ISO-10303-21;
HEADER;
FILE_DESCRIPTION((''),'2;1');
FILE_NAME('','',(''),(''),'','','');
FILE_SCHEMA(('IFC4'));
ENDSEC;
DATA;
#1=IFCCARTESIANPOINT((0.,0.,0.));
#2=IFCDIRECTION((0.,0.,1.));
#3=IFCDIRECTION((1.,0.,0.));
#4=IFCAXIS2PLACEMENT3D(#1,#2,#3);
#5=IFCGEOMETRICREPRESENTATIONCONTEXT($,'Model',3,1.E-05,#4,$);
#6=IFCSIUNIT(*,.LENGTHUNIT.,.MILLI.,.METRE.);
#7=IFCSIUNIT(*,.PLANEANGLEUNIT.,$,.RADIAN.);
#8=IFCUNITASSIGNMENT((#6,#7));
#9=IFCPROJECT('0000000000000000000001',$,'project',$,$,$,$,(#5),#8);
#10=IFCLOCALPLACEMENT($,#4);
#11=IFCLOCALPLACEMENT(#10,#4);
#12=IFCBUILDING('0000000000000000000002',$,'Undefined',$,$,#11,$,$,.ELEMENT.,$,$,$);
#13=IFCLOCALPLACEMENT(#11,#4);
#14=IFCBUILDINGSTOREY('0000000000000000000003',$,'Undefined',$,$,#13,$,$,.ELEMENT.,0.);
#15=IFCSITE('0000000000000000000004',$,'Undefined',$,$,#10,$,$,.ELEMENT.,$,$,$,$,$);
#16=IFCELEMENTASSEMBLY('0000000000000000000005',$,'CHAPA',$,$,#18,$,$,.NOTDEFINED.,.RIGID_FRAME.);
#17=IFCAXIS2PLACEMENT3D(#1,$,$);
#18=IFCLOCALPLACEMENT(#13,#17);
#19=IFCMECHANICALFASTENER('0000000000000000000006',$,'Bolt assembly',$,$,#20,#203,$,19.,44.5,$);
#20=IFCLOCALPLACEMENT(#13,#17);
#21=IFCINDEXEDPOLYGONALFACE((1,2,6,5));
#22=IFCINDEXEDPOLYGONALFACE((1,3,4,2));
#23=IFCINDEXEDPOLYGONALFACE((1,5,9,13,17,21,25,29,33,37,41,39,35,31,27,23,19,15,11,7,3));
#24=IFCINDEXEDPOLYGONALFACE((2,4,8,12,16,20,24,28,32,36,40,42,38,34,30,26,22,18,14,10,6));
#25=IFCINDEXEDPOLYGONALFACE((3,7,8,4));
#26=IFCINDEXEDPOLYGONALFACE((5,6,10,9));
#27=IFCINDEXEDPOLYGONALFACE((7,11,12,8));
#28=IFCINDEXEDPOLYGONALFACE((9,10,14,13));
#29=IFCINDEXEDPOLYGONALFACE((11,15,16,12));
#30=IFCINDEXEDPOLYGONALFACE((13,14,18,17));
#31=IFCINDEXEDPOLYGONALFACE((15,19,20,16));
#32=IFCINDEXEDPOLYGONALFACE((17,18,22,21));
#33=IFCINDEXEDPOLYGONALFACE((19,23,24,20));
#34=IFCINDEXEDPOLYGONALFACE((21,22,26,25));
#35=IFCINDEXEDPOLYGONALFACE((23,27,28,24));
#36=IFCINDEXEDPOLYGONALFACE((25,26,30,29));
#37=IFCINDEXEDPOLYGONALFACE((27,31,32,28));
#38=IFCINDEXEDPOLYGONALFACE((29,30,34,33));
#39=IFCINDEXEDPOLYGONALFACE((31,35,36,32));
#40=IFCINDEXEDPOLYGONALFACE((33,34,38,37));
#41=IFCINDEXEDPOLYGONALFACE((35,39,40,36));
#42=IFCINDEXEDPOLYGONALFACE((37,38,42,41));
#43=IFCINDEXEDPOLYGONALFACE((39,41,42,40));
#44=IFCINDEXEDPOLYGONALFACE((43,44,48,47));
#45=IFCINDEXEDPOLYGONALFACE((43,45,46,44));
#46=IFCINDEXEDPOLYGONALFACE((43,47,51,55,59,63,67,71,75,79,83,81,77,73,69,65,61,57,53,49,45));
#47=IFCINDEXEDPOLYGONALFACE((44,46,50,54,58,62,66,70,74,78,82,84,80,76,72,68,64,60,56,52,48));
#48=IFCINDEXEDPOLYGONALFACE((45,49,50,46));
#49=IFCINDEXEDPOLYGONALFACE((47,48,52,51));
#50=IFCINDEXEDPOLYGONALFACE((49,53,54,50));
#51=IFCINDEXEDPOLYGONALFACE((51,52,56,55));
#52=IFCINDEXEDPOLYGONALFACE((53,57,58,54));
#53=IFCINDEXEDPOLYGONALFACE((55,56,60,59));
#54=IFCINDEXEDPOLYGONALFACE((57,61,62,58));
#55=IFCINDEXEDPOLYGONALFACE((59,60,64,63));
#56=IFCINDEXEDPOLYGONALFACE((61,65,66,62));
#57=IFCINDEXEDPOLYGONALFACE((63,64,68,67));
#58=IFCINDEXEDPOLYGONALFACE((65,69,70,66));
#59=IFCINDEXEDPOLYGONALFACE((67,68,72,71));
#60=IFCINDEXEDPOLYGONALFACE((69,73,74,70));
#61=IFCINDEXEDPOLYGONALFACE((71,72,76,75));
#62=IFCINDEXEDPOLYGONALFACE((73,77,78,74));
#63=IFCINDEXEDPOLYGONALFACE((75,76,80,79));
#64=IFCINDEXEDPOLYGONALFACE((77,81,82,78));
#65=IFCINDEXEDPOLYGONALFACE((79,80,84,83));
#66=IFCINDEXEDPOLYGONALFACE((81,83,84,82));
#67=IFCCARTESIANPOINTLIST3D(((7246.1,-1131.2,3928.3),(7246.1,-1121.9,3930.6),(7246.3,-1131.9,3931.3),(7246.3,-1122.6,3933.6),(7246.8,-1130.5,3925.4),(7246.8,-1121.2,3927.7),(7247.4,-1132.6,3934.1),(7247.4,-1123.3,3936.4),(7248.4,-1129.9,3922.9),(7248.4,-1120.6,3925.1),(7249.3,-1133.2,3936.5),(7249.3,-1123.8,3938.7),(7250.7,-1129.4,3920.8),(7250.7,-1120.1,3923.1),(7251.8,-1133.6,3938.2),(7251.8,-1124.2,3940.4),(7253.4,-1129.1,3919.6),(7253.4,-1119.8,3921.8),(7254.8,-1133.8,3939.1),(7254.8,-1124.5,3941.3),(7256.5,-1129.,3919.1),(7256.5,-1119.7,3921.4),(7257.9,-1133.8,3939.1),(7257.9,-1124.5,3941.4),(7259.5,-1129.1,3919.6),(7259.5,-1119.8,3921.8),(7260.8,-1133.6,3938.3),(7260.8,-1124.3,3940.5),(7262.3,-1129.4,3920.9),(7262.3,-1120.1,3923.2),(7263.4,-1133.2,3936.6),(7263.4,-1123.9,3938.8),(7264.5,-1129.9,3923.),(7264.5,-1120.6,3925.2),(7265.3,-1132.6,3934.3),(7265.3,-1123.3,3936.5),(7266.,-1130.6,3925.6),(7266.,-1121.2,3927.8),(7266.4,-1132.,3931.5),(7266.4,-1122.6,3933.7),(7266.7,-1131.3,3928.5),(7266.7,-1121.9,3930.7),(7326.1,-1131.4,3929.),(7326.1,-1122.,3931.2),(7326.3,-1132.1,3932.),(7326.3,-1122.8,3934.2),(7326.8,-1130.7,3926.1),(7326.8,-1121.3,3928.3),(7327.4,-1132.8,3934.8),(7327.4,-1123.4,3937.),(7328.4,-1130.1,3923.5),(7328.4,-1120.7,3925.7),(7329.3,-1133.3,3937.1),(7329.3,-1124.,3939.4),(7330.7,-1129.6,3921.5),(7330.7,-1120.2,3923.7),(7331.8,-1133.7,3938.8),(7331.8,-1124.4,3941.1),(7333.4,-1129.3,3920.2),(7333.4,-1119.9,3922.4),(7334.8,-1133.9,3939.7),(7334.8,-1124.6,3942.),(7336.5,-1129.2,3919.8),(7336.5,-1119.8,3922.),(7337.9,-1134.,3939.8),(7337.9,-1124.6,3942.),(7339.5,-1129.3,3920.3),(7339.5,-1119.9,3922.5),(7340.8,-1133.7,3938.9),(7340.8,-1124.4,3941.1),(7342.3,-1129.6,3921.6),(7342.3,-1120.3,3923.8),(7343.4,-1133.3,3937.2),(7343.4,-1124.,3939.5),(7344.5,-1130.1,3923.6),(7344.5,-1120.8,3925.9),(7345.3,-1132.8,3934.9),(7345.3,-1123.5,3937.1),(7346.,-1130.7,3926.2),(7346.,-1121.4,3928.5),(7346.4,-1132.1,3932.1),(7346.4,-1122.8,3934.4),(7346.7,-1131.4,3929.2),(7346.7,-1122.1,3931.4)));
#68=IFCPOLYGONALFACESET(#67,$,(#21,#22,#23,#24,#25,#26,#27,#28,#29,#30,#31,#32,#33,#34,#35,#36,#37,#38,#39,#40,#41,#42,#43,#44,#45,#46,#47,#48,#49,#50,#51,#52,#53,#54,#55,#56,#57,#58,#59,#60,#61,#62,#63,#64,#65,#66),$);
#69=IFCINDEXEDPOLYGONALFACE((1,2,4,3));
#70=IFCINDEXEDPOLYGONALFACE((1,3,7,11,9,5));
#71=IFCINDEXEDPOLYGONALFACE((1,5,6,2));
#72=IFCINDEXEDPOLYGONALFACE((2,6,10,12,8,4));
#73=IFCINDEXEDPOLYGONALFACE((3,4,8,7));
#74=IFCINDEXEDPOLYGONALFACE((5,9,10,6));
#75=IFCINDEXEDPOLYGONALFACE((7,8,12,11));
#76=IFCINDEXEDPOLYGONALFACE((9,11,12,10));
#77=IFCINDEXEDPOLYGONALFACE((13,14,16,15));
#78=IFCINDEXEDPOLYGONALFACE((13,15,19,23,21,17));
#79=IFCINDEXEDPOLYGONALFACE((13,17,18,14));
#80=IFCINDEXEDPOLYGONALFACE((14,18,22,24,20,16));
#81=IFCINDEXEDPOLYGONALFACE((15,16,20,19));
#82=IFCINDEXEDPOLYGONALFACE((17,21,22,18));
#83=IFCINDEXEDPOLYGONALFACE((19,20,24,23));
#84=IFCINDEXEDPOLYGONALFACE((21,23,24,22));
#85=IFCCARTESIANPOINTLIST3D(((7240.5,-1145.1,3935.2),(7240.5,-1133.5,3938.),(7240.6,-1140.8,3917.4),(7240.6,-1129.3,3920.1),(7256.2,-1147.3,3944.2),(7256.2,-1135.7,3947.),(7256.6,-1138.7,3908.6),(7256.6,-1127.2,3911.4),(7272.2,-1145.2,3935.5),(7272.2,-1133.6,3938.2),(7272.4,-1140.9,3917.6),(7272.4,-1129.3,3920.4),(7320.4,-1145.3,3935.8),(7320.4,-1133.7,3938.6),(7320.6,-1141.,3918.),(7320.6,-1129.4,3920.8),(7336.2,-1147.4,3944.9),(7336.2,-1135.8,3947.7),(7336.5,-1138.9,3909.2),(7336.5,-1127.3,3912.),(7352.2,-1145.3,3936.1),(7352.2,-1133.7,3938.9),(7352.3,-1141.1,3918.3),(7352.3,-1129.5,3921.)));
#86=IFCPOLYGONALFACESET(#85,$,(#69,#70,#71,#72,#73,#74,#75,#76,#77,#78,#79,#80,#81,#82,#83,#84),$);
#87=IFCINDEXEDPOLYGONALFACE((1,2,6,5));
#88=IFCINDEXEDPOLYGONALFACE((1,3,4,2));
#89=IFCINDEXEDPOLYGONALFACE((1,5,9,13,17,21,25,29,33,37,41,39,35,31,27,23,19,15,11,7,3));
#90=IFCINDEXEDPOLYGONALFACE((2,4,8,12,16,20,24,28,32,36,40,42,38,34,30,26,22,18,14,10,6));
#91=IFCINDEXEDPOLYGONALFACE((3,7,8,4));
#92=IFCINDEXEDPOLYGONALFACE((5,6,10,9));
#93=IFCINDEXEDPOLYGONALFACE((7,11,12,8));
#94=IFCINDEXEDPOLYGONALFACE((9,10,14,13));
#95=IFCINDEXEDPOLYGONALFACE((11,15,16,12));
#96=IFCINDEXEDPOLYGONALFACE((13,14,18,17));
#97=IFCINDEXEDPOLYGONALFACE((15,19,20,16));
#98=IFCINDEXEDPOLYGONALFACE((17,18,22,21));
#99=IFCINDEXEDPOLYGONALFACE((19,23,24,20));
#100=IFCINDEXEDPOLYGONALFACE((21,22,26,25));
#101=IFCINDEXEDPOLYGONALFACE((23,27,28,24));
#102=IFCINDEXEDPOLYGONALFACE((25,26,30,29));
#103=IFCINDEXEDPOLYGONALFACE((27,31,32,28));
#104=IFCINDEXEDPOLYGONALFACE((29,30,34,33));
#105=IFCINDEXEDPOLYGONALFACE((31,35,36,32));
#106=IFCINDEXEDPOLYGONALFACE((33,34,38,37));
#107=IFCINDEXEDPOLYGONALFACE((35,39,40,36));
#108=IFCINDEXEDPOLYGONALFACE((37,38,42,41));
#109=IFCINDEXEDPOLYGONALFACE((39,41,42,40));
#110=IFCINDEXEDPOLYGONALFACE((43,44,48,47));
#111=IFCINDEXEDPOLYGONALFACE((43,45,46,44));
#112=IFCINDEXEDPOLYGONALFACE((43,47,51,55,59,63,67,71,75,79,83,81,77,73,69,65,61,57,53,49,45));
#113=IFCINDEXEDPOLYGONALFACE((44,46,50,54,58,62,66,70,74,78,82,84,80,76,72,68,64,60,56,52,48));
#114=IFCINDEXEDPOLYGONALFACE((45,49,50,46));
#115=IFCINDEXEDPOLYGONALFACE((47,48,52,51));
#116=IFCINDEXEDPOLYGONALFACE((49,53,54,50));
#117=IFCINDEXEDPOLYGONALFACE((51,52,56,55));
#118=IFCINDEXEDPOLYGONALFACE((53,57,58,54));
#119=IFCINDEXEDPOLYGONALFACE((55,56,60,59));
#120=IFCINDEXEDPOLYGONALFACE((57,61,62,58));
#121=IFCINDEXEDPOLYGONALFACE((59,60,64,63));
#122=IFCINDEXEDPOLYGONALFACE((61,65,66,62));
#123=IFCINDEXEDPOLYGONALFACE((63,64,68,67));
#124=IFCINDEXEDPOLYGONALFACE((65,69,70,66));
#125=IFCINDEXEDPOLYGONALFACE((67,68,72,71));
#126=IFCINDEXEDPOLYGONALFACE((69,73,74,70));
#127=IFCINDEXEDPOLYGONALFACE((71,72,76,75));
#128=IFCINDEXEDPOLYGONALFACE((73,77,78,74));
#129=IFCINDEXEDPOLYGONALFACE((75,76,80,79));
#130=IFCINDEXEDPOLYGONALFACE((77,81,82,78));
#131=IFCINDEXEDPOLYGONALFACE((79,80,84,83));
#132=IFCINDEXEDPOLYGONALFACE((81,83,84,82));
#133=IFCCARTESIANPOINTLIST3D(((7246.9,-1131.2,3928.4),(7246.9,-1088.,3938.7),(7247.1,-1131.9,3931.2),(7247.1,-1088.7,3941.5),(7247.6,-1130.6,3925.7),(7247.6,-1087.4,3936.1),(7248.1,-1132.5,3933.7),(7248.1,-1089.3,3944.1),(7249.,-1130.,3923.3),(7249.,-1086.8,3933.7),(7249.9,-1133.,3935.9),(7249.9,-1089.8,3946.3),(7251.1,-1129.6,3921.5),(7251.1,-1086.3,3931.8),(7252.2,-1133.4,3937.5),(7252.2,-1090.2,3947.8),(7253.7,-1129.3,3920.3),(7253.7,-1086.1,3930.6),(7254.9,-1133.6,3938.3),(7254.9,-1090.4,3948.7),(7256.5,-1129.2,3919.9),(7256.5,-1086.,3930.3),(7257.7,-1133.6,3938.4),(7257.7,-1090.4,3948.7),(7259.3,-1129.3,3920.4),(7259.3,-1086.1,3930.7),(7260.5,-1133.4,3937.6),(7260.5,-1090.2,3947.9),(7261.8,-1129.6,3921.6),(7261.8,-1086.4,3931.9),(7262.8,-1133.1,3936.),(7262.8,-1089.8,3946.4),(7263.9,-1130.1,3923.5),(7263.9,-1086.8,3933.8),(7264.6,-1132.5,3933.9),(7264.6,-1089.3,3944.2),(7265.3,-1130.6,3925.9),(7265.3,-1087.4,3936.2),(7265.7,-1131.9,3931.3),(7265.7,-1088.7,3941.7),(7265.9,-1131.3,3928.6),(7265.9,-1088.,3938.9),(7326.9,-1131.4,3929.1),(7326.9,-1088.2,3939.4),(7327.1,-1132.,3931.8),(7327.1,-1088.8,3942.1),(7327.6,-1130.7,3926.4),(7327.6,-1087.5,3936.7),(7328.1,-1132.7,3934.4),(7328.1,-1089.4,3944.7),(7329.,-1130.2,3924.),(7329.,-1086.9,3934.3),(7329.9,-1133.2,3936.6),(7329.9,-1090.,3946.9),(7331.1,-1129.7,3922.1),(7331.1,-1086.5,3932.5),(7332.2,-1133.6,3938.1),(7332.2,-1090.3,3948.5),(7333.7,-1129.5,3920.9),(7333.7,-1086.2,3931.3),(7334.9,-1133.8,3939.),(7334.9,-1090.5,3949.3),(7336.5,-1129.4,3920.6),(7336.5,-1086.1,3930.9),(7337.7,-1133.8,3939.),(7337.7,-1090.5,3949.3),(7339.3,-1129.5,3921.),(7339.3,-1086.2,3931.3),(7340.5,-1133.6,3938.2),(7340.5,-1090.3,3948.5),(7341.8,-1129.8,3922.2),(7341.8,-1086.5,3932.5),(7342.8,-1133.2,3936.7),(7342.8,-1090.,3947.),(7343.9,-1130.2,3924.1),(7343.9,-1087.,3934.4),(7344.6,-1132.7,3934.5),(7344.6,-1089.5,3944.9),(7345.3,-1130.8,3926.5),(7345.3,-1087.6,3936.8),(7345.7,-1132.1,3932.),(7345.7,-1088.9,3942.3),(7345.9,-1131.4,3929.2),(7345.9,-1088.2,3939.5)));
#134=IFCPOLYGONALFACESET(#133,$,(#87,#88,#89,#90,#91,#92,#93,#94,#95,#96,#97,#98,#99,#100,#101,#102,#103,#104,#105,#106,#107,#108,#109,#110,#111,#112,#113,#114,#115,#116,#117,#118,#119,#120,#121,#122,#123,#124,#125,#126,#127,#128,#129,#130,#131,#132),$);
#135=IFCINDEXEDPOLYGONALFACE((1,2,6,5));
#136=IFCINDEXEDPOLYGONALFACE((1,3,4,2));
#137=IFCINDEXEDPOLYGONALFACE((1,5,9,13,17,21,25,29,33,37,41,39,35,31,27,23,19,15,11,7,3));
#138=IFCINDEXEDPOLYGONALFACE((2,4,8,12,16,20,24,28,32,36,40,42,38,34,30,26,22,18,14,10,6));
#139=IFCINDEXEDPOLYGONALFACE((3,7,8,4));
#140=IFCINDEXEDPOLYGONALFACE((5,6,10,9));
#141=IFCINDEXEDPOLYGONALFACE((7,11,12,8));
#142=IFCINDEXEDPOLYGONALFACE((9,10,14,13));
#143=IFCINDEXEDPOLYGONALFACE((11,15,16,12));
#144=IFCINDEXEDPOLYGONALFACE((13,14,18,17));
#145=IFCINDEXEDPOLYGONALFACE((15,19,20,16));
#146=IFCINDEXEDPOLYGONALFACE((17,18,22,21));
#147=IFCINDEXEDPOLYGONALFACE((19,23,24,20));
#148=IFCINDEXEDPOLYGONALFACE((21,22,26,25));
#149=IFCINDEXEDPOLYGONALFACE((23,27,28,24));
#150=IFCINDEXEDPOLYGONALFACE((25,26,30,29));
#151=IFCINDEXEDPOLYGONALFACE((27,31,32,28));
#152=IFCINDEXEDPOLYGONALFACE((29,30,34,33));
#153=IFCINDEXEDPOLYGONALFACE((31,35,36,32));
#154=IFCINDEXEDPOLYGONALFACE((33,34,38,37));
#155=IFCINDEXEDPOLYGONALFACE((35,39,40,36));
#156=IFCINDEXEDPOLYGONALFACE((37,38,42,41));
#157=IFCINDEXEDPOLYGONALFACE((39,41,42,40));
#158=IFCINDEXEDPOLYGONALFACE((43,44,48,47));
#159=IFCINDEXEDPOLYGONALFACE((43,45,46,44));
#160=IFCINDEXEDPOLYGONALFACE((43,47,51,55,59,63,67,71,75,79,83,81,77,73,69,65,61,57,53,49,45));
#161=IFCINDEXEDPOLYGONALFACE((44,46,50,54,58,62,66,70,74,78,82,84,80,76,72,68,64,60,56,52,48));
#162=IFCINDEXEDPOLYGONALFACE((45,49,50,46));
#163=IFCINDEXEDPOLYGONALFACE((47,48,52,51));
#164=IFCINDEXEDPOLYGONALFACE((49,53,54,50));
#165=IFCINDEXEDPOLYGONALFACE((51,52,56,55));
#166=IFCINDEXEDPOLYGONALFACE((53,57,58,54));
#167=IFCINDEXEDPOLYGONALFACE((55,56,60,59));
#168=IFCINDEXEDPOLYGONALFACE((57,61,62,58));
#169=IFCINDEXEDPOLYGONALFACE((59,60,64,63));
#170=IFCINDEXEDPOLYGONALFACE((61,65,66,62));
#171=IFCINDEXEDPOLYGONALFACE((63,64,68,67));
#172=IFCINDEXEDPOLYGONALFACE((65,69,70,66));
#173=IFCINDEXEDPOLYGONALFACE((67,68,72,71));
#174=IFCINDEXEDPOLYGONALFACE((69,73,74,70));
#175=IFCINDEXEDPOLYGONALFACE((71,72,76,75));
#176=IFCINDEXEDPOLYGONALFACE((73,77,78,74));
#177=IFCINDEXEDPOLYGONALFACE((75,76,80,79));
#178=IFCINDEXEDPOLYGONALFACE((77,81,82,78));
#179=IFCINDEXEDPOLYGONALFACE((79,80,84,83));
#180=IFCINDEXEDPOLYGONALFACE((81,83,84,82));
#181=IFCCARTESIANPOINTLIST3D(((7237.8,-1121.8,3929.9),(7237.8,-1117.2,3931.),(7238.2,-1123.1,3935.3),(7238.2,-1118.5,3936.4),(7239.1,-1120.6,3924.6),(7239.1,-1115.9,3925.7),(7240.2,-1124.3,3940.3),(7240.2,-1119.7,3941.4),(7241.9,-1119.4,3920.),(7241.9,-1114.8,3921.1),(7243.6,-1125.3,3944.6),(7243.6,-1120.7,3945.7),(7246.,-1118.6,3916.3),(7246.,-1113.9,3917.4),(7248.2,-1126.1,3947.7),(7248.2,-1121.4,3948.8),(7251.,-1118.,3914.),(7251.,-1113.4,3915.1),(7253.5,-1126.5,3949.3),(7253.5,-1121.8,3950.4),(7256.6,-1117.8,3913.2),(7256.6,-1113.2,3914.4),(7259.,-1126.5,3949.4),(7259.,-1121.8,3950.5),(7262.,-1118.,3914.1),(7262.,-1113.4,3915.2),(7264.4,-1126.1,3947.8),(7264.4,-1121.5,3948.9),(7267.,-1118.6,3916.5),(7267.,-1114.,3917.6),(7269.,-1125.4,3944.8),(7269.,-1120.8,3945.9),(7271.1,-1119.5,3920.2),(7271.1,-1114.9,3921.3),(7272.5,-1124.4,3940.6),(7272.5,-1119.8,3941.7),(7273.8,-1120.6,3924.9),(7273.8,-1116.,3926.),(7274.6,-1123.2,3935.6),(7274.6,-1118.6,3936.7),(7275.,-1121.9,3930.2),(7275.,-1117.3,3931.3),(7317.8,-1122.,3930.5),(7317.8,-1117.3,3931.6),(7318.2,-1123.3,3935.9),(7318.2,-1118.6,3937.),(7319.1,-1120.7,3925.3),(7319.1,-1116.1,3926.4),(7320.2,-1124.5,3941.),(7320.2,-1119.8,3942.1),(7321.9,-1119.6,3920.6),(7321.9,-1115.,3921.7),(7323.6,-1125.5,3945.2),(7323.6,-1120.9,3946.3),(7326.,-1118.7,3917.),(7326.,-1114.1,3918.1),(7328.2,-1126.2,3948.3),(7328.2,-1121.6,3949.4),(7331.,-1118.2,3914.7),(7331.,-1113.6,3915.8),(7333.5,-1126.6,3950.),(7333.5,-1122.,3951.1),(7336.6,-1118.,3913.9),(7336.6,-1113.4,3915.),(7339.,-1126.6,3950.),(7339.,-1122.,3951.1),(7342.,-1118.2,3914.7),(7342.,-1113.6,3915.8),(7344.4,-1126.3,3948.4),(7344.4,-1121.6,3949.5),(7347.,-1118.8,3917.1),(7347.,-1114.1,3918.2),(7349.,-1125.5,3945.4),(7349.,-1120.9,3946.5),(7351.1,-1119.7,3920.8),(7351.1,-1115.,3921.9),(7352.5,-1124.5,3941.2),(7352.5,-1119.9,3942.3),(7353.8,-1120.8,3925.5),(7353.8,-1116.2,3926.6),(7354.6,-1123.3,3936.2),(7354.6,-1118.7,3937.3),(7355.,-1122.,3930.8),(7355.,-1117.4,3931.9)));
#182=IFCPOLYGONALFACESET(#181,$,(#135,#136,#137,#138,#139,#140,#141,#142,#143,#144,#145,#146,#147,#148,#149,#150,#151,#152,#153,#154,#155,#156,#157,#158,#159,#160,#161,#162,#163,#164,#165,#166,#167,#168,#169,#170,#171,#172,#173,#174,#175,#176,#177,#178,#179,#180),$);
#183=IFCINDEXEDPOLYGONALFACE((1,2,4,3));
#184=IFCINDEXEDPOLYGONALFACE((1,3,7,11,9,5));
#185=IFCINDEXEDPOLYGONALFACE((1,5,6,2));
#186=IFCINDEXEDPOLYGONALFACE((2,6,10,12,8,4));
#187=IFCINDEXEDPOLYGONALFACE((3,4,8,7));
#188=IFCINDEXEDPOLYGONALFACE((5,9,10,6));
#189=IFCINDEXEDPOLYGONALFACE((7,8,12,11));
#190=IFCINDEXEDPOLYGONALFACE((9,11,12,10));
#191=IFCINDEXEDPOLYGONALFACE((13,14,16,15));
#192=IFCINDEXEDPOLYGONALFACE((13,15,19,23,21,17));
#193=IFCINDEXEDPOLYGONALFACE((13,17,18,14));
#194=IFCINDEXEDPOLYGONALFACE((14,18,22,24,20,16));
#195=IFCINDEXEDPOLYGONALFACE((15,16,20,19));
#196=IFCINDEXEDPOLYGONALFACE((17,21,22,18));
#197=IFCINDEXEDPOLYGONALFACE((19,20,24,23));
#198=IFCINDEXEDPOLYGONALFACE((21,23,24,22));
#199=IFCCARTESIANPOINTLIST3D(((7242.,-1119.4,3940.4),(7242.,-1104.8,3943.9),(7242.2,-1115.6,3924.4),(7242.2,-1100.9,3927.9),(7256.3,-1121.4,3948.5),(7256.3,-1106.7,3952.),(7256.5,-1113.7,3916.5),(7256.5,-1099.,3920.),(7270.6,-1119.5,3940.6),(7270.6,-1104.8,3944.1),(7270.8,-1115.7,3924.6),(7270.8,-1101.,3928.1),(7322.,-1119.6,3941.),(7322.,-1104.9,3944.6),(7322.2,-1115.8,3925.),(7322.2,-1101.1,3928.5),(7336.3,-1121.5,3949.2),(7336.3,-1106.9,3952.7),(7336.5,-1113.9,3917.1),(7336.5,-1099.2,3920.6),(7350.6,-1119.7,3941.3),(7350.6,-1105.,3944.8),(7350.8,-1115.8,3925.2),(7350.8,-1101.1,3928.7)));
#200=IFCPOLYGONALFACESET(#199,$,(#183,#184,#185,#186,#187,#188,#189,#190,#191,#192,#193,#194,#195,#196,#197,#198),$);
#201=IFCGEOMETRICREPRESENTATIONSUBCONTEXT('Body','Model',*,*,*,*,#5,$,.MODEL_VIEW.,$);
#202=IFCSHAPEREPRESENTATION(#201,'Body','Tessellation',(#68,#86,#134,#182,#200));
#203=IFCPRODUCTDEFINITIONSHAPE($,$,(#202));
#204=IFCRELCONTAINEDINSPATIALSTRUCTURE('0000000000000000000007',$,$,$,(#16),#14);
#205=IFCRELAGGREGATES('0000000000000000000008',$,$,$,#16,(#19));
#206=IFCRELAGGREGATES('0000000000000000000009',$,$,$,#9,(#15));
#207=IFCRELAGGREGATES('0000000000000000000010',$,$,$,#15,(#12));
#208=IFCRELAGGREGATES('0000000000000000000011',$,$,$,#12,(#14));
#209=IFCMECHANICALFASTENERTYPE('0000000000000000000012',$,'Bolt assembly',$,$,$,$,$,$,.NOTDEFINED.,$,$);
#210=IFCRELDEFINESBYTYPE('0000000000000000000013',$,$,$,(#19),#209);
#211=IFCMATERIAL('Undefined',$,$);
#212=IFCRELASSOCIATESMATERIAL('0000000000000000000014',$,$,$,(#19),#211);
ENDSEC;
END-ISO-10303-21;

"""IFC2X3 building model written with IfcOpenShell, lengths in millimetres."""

from ifc_helpers import new_model, si_unit, frame, origin_with_axes, origin_2d_with_axis, place, context, subcontext, project, spatial, polyline, circle, outline, extrude, source, transform, mapped, material, type_object, element, aggregate, save


model = new_model("IFC2X3")

# Units and contexts
model_context = context("Model", 3, precision=1e-05, world=origin_with_axes())
body_context = subcontext(model_context, "Body", "Model", "MODEL_VIEW")
ifc_project = project(units=[si_unit("LENGTHUNIT", "METRE", prefix="MILLI"), si_unit("PLANEANGLEUNIT", "RADIAN")], contexts=[model_context])

# Site, building, storey
site_placement = place(None, origin_with_axes())
site = spatial("IfcSite", under=ifc_project, at=site_placement, Name="Undefined", CompositionType="ELEMENT")
building_placement = place(site_placement, origin_with_axes())
building = spatial("IfcBuilding", under=site, at=building_placement, Name="Undefined", CompositionType="ELEMENT")
storey_placement = place(building_placement, origin_with_axes())
storey = spatial("IfcBuildingStorey", under=building, at=storey_placement, Name="Undefined", CompositionType="ELEMENT", Elevation=0.0)

# Element assembly
assembly_1_placement = place(storey_placement, origin_with_axes())
assembly_1 = element("IfcElementAssembly", 1, at=assembly_1_placement, inside=storey, Name="CHAPA", AssemblyPlace="NOTDEFINED", PredefinedType="RIGID_FRAME")

# Shared definitions
ifc_material_1 = material(Name="Undefined")
mechanical_fastener_type = type_object("IfcMechanicalFastenerType", Name="Bolt assembly")

# Mechanical fastener
shared_shape_1 = source(origin_with_axes(), body_context, "Body", "SweptSolid", [
    extrude(circle(Radius=10.3, at=origin_2d_with_axis()), frame((0.0, 0.0, 0.0), z_axis=(0.0, 1.0, 0.0), x_axis=(1.0, 0.0, 0.0)), (0.0, 0.0, 1.0), 9.6),
    extrude(outline(polyline([(18.3, 0.0), (9.2, 15.9), (-9.2, 15.9), (-18.3, 0.0), (-9.2, -15.9), (9.2, -15.9), (18.3, 0.0)])), frame((0.0, -11.9, 0.0), z_axis=(0.0, 1.0, 0.0), x_axis=(1.0, 0.0, 0.0)), (0.0, 0.0, 1.0), 11.9),
    extrude(circle(Radius=9.5, at=origin_2d_with_axis()), frame((0.0, 0.0, 0.0), z_axis=(0.0, 1.0, 0.0), x_axis=(1.0, 0.0, 0.0)), (0.0, 0.0, 1.0), 44.5),
    extrude(circle(Radius=18.7, at=origin_2d_with_axis()), frame((0.0, 9.5, 0.0), z_axis=(0.0, 1.0, 0.0), x_axis=(1.0, 0.0, 0.0)), (0.0, 0.0, 1.0), 4.8),
    extrude(outline(polyline([(16.5, 0.0), (8.2, 14.3), (-8.2, 14.3), (-16.5, 0.0), (-8.2, -14.3), (8.2, -14.3), (16.5, 0.0)])), frame((0.0, 14.3, 0.0), z_axis=(0.0, 1.0, 0.0), x_axis=(1.0, 0.0, 0.0)), (0.0, 0.0, 1.0), 15.1),
])
mechanical_fastener_1_placement = place(assembly_1_placement, frame((7296.4, -1131.5, 3929.5), z_axis=(0.999966, -0.001918, 0.008027), x_axis=(0.008253, 0.23249, -0.972564)))
mechanical_fastener_1 = element("IfcMechanicalFastener", 2, at=mechanical_fastener_1_placement, type_object=mechanical_fastener_type, material=ifc_material_1, Name="Bolt assembly", NominalDiameter=19.0, NominalLength=44.5, context=body_context, shape_type="MappedRepresentation", body=[
    mapped(shared_shape_1, transform((0.0, 0.0, -40.0))),
    mapped(shared_shape_1, transform((0.0, 0.0, 40.0))),
])
aggregate(assembly_1, [mechanical_fastener_1])

save(model, "model.ifc")
